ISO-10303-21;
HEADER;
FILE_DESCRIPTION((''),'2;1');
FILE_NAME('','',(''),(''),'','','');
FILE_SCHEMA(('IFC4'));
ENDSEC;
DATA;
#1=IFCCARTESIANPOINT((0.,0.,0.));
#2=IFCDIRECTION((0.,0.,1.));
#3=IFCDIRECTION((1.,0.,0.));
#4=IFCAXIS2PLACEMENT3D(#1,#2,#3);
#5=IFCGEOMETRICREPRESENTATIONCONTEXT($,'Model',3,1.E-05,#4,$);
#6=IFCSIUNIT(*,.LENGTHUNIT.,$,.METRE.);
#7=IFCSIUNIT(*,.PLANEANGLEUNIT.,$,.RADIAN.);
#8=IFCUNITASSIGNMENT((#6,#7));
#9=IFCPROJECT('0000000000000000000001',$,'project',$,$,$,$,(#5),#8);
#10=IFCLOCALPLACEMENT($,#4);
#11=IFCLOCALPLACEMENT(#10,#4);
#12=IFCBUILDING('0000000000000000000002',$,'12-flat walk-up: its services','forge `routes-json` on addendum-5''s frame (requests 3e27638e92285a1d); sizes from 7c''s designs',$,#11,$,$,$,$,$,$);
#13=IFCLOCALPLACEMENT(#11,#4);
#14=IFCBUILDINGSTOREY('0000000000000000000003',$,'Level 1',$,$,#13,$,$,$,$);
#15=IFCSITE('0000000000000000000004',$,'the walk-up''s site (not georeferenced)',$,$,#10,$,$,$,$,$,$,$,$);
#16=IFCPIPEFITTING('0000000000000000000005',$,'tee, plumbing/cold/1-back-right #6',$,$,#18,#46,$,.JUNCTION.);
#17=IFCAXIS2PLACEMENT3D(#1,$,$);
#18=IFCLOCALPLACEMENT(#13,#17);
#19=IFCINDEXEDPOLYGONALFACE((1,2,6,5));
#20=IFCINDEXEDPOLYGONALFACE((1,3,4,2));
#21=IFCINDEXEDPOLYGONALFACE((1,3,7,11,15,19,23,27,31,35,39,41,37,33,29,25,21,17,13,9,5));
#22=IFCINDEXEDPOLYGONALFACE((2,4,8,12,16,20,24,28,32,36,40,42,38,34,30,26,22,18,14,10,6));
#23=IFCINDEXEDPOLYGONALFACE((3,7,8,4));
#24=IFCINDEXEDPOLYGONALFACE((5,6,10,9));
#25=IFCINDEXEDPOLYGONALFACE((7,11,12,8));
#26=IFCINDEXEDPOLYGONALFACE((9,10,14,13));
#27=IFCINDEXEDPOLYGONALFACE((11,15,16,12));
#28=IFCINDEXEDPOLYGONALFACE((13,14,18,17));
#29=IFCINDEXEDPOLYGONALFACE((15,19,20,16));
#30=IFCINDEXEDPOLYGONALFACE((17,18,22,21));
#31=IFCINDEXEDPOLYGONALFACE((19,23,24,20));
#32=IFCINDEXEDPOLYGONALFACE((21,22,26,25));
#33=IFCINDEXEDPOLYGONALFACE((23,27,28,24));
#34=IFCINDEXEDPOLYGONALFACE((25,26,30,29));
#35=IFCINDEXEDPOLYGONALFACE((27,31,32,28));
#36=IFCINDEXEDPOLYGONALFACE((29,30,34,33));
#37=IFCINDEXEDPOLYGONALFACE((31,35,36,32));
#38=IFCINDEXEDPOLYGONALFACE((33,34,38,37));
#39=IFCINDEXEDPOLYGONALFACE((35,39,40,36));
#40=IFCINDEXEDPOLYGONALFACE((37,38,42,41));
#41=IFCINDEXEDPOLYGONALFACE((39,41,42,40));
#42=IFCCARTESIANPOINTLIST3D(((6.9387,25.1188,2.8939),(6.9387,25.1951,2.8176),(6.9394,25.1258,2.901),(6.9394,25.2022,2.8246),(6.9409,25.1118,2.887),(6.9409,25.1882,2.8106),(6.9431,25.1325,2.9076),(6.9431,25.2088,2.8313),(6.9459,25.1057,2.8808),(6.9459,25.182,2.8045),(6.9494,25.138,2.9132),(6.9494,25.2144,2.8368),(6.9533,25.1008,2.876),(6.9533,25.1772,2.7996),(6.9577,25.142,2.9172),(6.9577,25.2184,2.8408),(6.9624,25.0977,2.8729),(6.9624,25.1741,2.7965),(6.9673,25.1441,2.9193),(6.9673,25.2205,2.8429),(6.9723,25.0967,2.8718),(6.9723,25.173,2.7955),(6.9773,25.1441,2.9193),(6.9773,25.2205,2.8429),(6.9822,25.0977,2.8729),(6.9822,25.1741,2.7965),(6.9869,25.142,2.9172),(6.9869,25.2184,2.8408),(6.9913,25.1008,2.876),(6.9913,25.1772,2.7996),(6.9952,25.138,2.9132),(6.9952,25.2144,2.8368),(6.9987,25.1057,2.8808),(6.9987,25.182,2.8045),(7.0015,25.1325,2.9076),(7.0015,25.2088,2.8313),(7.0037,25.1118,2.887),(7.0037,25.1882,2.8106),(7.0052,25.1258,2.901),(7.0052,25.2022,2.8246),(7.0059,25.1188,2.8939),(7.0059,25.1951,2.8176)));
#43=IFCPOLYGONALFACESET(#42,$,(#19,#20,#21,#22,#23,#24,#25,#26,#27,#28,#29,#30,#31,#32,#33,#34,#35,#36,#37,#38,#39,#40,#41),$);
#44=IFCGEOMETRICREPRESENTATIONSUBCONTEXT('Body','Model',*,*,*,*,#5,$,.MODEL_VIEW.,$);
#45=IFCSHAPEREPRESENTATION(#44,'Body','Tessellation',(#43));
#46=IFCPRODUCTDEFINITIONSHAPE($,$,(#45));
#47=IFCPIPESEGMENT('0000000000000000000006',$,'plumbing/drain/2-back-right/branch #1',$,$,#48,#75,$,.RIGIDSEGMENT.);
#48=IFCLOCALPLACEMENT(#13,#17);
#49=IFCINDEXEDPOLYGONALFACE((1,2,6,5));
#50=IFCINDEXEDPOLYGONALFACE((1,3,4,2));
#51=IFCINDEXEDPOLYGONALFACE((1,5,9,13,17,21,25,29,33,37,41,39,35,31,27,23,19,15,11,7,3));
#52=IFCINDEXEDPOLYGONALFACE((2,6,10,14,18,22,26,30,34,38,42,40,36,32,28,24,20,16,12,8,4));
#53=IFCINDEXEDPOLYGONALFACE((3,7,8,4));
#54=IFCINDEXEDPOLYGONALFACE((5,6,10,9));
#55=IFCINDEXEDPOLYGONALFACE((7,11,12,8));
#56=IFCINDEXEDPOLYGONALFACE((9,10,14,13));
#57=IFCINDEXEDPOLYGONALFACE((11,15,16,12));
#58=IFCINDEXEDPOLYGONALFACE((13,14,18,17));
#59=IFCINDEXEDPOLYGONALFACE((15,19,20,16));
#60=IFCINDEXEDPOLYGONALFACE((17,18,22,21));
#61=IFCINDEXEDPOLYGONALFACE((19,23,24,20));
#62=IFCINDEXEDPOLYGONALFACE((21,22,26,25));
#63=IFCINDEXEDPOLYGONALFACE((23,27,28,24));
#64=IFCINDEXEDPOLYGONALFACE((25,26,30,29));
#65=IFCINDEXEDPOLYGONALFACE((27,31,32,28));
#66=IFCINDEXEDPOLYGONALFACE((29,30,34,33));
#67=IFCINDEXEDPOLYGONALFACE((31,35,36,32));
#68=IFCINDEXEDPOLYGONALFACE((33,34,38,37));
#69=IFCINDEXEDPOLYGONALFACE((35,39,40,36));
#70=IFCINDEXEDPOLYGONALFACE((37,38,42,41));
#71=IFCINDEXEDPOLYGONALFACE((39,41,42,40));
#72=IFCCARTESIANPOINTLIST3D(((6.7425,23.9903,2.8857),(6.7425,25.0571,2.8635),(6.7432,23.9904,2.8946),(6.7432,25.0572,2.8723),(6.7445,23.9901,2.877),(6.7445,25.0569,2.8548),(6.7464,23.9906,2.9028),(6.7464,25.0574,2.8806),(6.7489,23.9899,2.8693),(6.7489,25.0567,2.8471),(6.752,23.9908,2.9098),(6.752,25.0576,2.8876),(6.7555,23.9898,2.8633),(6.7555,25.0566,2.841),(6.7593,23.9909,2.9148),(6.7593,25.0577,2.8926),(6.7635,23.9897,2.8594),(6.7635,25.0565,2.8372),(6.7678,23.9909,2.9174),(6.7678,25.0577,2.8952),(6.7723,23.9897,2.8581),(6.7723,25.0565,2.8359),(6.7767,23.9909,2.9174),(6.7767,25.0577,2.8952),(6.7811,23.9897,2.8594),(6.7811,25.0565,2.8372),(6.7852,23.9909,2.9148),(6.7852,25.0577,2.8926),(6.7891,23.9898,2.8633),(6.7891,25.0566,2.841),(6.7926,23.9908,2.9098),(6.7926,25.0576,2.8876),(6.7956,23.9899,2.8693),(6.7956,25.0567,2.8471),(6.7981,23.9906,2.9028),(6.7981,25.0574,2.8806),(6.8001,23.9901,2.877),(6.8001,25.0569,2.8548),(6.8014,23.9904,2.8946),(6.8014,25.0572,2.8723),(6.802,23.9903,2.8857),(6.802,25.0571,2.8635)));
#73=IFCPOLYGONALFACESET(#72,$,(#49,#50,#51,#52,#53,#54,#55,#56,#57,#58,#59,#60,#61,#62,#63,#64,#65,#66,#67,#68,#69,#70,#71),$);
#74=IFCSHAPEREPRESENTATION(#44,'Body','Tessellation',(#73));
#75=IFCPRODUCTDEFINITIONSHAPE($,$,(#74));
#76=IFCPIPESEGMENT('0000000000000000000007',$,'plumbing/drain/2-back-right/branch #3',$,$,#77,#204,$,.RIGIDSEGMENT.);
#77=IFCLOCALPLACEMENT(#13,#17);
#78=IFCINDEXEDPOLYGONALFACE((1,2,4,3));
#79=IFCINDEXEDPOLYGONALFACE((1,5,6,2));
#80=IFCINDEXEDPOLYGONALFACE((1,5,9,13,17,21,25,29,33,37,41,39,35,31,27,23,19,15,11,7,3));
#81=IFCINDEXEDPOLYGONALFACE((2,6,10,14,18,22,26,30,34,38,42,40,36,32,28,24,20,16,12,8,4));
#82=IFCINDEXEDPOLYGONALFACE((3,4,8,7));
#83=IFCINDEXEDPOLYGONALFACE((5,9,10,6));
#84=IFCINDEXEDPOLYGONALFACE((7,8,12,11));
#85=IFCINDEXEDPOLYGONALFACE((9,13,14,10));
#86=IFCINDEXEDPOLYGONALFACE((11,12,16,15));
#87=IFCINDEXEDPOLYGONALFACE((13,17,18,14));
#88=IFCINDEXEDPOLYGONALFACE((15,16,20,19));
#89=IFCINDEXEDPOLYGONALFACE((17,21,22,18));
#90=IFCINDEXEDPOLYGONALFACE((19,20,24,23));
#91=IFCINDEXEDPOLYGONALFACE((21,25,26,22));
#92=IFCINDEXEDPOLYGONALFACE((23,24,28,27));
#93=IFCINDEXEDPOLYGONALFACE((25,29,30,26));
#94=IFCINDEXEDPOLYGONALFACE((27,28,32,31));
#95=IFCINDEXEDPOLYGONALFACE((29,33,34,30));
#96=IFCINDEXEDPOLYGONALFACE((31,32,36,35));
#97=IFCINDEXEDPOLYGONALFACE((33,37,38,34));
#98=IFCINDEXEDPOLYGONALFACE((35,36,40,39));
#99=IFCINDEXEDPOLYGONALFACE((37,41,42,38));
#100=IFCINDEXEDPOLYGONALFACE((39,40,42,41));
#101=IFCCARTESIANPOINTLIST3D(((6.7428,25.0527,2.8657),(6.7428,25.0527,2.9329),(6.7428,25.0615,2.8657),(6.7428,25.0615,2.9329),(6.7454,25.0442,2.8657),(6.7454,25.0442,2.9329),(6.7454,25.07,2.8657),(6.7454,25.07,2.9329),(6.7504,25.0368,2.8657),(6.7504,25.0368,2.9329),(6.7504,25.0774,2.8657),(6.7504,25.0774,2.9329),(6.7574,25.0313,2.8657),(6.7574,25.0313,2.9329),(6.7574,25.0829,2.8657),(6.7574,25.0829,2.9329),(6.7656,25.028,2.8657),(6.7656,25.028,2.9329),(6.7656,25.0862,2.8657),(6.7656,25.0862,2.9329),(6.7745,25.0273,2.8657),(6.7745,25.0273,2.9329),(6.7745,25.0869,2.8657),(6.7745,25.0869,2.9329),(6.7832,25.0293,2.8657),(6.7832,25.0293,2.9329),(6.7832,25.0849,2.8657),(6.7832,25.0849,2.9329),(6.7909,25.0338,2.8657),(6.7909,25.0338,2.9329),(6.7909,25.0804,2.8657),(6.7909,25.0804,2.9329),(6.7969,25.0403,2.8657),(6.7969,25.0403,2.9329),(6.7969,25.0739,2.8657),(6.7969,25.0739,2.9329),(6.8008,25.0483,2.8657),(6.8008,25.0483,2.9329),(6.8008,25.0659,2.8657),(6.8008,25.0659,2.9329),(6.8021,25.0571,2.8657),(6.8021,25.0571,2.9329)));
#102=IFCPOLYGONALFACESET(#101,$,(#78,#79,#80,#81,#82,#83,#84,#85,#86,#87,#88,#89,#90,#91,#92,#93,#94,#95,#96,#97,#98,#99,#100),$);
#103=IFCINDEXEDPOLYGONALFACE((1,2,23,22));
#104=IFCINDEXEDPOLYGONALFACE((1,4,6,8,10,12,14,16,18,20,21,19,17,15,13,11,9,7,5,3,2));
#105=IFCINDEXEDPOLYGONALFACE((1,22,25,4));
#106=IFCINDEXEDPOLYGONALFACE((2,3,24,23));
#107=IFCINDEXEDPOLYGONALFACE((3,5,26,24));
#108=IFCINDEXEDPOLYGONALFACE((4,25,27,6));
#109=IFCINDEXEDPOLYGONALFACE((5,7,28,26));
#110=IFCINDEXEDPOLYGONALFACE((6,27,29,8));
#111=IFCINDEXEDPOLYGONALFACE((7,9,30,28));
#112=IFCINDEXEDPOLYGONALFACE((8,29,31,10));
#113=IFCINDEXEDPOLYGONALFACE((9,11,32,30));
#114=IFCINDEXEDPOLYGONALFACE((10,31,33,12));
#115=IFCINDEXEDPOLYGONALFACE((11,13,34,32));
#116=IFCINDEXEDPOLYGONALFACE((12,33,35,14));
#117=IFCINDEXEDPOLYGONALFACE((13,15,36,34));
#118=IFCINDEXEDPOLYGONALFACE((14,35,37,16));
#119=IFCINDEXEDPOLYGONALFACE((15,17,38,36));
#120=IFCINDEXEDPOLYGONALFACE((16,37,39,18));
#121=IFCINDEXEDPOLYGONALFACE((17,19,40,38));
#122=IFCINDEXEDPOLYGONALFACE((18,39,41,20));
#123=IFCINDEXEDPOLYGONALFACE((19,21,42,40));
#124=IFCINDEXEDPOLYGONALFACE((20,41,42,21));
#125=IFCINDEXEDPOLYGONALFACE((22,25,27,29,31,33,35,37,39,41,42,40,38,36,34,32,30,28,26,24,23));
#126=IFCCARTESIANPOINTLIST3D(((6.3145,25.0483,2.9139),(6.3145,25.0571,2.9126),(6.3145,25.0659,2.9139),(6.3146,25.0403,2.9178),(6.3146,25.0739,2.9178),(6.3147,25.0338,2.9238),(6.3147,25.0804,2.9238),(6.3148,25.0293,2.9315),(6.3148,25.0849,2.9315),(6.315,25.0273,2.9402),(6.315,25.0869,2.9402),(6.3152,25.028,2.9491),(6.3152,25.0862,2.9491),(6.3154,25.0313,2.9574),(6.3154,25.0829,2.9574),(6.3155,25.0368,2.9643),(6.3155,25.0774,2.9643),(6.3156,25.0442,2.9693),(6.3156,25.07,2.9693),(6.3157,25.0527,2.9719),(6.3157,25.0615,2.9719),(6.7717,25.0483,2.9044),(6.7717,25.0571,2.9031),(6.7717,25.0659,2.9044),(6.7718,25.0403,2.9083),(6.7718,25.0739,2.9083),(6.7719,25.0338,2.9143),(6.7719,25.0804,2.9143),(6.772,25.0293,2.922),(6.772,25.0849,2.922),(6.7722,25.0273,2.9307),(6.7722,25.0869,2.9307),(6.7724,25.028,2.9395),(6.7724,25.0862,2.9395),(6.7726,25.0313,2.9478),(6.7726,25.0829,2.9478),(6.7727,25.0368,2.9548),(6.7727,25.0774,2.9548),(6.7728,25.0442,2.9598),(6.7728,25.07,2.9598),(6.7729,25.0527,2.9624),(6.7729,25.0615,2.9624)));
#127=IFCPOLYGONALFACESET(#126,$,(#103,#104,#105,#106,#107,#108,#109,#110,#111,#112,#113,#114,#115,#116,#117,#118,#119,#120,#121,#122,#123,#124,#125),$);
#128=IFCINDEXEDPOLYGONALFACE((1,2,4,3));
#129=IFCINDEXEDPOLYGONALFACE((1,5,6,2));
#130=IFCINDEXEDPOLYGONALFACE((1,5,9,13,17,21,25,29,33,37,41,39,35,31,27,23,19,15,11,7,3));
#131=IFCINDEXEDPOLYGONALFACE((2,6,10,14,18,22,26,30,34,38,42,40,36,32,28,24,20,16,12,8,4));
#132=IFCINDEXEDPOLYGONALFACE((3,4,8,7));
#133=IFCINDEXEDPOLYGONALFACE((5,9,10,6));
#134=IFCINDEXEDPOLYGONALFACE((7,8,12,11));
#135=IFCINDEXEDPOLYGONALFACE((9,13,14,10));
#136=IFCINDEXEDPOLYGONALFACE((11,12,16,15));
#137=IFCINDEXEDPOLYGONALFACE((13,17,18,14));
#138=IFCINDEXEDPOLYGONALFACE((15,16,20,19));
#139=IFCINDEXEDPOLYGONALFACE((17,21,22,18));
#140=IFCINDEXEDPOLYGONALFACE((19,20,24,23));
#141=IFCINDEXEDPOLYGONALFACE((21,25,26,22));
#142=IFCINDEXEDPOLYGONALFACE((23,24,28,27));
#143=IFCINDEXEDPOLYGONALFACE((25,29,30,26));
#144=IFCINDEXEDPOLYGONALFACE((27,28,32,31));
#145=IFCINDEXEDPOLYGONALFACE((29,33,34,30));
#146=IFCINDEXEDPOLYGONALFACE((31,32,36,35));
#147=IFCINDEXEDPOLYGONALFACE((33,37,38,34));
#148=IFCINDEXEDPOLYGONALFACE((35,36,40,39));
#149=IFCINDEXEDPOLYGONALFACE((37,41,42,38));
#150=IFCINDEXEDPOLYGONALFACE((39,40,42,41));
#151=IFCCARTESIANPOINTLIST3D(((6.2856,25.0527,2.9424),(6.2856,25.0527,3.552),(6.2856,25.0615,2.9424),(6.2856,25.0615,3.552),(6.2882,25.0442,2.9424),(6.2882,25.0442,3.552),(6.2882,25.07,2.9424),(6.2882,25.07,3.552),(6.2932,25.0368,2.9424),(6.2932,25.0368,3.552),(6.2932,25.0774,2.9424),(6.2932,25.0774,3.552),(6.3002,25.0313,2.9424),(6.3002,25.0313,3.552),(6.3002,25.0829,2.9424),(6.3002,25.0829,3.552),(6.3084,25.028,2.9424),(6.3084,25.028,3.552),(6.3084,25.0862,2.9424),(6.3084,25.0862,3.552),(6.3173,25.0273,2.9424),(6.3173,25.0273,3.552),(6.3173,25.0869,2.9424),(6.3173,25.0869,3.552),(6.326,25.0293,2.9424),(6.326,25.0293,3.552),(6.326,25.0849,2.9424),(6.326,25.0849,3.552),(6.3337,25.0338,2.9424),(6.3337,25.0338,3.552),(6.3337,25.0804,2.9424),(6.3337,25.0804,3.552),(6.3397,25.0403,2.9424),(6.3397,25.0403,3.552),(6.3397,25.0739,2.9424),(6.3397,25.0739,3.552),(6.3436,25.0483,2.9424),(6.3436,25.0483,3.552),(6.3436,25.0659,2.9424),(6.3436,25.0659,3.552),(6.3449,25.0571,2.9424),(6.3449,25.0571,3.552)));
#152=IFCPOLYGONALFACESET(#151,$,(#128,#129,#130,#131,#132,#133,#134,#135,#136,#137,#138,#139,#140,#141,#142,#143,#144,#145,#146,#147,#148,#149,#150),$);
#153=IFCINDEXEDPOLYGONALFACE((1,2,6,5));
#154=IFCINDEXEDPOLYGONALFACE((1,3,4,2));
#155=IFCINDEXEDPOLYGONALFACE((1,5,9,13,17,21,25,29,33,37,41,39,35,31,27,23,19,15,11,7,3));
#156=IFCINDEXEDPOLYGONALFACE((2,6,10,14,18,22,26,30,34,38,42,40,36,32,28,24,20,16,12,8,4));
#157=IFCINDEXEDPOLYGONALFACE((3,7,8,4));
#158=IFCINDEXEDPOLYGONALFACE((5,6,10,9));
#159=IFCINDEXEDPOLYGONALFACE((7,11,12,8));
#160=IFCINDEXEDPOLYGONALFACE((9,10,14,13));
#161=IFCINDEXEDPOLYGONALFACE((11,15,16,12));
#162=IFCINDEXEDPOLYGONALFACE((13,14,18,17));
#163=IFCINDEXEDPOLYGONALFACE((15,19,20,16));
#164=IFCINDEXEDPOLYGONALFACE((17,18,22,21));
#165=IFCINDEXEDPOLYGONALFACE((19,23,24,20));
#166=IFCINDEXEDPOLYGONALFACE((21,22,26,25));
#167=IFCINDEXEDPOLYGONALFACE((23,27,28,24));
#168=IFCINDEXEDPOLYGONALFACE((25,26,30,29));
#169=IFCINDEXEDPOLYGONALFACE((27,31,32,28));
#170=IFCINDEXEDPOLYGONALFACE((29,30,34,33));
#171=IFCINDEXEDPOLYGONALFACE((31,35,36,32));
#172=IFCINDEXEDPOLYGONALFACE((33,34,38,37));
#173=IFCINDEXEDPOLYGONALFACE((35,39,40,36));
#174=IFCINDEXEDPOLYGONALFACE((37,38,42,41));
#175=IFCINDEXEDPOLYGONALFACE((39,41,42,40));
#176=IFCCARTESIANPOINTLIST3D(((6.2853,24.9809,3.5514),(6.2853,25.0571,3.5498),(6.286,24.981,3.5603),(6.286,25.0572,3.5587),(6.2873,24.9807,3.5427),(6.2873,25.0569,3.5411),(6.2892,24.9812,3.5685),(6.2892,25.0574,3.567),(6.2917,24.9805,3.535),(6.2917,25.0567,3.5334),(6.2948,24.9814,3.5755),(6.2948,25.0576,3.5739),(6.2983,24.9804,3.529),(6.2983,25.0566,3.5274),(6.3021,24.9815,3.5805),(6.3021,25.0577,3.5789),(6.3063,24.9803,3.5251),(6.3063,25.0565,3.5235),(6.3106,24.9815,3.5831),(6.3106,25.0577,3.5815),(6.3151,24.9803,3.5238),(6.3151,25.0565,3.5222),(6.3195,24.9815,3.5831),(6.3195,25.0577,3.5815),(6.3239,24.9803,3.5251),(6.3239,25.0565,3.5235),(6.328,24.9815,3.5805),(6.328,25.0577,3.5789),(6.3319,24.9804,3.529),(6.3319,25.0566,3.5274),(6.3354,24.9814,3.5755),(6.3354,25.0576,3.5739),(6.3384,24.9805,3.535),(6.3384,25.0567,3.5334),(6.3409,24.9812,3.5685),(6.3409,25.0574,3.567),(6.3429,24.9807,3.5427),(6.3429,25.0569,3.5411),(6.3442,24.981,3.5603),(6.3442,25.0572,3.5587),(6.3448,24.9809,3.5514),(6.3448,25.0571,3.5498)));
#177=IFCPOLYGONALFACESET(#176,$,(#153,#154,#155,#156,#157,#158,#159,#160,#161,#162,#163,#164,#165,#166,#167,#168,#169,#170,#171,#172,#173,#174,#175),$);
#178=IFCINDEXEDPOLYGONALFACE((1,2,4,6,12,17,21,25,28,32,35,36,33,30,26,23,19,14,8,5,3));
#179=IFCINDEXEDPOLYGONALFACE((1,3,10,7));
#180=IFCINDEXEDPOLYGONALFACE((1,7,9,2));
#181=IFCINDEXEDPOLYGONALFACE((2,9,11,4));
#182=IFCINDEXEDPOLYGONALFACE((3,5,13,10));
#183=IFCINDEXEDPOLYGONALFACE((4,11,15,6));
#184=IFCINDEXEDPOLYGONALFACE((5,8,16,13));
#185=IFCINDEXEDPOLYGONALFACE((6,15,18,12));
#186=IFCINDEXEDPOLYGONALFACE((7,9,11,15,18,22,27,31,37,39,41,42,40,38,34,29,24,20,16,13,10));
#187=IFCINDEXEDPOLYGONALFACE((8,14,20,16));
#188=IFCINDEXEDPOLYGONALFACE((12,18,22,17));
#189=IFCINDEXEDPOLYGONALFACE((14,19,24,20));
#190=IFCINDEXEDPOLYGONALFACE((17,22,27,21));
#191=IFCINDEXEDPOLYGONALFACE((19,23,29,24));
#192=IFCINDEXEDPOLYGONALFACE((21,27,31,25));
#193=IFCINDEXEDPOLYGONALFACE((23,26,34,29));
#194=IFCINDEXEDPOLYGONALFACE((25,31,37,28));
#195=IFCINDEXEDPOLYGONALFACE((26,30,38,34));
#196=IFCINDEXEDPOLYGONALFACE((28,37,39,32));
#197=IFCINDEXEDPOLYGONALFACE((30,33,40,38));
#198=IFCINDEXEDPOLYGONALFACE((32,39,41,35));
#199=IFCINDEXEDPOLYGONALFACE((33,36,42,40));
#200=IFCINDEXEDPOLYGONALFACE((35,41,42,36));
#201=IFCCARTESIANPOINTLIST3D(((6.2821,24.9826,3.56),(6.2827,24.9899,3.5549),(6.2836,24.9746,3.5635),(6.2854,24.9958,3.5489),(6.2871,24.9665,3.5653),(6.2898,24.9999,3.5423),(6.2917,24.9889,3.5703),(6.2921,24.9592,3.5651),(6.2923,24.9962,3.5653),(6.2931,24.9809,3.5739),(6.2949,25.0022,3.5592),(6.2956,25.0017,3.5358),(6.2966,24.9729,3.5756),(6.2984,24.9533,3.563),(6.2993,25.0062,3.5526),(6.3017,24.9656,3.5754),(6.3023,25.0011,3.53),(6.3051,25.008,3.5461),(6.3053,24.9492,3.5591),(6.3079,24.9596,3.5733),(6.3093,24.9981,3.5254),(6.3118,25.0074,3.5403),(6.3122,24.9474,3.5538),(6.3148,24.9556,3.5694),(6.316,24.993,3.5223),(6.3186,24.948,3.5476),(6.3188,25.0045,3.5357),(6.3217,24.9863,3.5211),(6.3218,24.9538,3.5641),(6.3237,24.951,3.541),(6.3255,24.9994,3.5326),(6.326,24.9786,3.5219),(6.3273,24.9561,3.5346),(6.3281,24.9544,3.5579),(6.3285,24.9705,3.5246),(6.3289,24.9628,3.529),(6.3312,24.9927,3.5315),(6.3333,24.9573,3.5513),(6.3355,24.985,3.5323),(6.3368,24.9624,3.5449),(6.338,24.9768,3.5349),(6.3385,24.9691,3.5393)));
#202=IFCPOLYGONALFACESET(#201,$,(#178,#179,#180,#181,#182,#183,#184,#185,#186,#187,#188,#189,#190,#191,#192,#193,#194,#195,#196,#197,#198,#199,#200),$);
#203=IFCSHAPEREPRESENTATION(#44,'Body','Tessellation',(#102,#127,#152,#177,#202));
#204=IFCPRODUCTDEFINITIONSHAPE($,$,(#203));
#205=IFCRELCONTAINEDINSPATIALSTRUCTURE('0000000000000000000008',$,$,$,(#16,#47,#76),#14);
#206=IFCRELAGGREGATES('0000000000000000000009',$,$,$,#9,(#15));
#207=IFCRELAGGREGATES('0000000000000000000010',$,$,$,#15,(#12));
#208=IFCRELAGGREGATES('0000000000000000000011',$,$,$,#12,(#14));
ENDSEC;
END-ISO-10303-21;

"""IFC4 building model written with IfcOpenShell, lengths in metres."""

from ifc_helpers import new_model, entity, si_unit, frame, origin_with_axes, place, context, subcontext, project, spatial, element, save


model = new_model("IFC4")

# Units and contexts
model_context = context("Model", 3, precision=1e-05, world=origin_with_axes())
body_context = subcontext(model_context, "Body", "Model", "MODEL_VIEW")
ifc_project = project(units=[si_unit("LENGTHUNIT", "METRE"), si_unit("PLANEANGLEUNIT", "RADIAN")], contexts=[model_context])

# Site, building, storey
site_placement = place(None, origin_with_axes())
site = spatial("IfcSite", under=ifc_project, at=site_placement, Name="the walk-up's site (not georeferenced)")
building_placement = place(site_placement, origin_with_axes())
building = spatial("IfcBuilding", under=site, at=building_placement, Name="12-flat walk-up: its services", Description="forge `routes-json` on addendum-5's frame (requests 3e27638e92285a1d); sizes from 7c's designs")
storey_placement = place(building_placement, origin_with_axes())
storey = spatial("IfcBuildingStorey", under=building, at=storey_placement, Name="Level 1")

# Pipe fitting
pipe_fitting_1_placement = place(storey_placement, frame((6.9723, 25.1205, 2.8957), z_axis=(0.0, 0.0, 1.0), x_axis=(1.0, 0.0, 0.0)))
element("IfcPipeFitting", 1, at=pipe_fitting_1_placement, inside=storey, Name="tee, plumbing/cold/1-back-right #6", PredefinedType="JUNCTION", context=body_context, shape_type="AdvancedSweptSolid", body=[
    entity("IfcSweptDiskSolid", entity("IfcPolyline", [entity("IfcCartesianPoint", [0.0, 0.0, 0.0]), entity("IfcCartesianPoint", [0.0, 0.0763, -0.0763])]), 0.0337),
])

# Pipe segments
pipe_segment_1_placement = place(storey_placement, frame((6.7723, 25.0571, 2.8657), z_axis=(0.0, 0.0, 1.0), x_axis=(1.0, 0.0, 0.0)))
element("IfcPipeSegment", 2, at=pipe_segment_1_placement, inside=storey, Name="plumbing/drain/2-back-right/branch #1", PredefinedType="RIGIDSEGMENT", context=body_context, shape_type="AdvancedSweptSolid", body=[
    entity("IfcSweptDiskSolid", entity("IfcPolyline", [entity("IfcCartesianPoint", [0.0, 0.0, 0.0]), entity("IfcCartesianPoint", [0.0, -1.0668, 0.0222])]), 0.0298),
])
pipe_segment_2_placement = place(storey_placement, frame((6.7723, 25.0571, 2.8657), z_axis=(0.0, 0.0, 1.0), x_axis=(1.0, 0.0, 0.0)))
element("IfcPipeSegment", 3, at=pipe_segment_2_placement, inside=storey, Name="plumbing/drain/2-back-right/branch #3", PredefinedType="RIGIDSEGMENT", context=body_context, shape_type="AdvancedSweptSolid", body=[
    entity("IfcSweptDiskSolid", entity("IfcPolyline", [entity("IfcCartesianPoint", [0.0, 0.0, 0.0]), entity("IfcCartesianPoint", [0.0, 0.0, 0.0672])]), 0.0298),
    entity("IfcSweptDiskSolid", entity("IfcPolyline", [entity("IfcCartesianPoint", [0.0, 0.0, 0.0672]), entity("IfcCartesianPoint", [-0.4572, 0.0, 0.0767])]), 0.0298),
    entity("IfcSweptDiskSolid", entity("IfcPolyline", [entity("IfcCartesianPoint", [-0.4572, 0.0, 0.0767]), entity("IfcCartesianPoint", [-0.4572, 0.0, 0.6863])]), 0.0298),
    entity("IfcSweptDiskSolid", entity("IfcPolyline", [entity("IfcCartesianPoint", [-0.4572, 0.0, 0.6863]), entity("IfcCartesianPoint", [-0.4572, -0.0762, 0.6879])]), 0.0298),
    entity("IfcSweptDiskSolid", entity("IfcPolyline", [entity("IfcCartesianPoint", [-0.4572, -0.0762, 0.6879]), entity("IfcCartesianPoint", [-0.4667, -0.0826, 0.6776])]), 0.0298),
])

save(model, "model.ifc")
